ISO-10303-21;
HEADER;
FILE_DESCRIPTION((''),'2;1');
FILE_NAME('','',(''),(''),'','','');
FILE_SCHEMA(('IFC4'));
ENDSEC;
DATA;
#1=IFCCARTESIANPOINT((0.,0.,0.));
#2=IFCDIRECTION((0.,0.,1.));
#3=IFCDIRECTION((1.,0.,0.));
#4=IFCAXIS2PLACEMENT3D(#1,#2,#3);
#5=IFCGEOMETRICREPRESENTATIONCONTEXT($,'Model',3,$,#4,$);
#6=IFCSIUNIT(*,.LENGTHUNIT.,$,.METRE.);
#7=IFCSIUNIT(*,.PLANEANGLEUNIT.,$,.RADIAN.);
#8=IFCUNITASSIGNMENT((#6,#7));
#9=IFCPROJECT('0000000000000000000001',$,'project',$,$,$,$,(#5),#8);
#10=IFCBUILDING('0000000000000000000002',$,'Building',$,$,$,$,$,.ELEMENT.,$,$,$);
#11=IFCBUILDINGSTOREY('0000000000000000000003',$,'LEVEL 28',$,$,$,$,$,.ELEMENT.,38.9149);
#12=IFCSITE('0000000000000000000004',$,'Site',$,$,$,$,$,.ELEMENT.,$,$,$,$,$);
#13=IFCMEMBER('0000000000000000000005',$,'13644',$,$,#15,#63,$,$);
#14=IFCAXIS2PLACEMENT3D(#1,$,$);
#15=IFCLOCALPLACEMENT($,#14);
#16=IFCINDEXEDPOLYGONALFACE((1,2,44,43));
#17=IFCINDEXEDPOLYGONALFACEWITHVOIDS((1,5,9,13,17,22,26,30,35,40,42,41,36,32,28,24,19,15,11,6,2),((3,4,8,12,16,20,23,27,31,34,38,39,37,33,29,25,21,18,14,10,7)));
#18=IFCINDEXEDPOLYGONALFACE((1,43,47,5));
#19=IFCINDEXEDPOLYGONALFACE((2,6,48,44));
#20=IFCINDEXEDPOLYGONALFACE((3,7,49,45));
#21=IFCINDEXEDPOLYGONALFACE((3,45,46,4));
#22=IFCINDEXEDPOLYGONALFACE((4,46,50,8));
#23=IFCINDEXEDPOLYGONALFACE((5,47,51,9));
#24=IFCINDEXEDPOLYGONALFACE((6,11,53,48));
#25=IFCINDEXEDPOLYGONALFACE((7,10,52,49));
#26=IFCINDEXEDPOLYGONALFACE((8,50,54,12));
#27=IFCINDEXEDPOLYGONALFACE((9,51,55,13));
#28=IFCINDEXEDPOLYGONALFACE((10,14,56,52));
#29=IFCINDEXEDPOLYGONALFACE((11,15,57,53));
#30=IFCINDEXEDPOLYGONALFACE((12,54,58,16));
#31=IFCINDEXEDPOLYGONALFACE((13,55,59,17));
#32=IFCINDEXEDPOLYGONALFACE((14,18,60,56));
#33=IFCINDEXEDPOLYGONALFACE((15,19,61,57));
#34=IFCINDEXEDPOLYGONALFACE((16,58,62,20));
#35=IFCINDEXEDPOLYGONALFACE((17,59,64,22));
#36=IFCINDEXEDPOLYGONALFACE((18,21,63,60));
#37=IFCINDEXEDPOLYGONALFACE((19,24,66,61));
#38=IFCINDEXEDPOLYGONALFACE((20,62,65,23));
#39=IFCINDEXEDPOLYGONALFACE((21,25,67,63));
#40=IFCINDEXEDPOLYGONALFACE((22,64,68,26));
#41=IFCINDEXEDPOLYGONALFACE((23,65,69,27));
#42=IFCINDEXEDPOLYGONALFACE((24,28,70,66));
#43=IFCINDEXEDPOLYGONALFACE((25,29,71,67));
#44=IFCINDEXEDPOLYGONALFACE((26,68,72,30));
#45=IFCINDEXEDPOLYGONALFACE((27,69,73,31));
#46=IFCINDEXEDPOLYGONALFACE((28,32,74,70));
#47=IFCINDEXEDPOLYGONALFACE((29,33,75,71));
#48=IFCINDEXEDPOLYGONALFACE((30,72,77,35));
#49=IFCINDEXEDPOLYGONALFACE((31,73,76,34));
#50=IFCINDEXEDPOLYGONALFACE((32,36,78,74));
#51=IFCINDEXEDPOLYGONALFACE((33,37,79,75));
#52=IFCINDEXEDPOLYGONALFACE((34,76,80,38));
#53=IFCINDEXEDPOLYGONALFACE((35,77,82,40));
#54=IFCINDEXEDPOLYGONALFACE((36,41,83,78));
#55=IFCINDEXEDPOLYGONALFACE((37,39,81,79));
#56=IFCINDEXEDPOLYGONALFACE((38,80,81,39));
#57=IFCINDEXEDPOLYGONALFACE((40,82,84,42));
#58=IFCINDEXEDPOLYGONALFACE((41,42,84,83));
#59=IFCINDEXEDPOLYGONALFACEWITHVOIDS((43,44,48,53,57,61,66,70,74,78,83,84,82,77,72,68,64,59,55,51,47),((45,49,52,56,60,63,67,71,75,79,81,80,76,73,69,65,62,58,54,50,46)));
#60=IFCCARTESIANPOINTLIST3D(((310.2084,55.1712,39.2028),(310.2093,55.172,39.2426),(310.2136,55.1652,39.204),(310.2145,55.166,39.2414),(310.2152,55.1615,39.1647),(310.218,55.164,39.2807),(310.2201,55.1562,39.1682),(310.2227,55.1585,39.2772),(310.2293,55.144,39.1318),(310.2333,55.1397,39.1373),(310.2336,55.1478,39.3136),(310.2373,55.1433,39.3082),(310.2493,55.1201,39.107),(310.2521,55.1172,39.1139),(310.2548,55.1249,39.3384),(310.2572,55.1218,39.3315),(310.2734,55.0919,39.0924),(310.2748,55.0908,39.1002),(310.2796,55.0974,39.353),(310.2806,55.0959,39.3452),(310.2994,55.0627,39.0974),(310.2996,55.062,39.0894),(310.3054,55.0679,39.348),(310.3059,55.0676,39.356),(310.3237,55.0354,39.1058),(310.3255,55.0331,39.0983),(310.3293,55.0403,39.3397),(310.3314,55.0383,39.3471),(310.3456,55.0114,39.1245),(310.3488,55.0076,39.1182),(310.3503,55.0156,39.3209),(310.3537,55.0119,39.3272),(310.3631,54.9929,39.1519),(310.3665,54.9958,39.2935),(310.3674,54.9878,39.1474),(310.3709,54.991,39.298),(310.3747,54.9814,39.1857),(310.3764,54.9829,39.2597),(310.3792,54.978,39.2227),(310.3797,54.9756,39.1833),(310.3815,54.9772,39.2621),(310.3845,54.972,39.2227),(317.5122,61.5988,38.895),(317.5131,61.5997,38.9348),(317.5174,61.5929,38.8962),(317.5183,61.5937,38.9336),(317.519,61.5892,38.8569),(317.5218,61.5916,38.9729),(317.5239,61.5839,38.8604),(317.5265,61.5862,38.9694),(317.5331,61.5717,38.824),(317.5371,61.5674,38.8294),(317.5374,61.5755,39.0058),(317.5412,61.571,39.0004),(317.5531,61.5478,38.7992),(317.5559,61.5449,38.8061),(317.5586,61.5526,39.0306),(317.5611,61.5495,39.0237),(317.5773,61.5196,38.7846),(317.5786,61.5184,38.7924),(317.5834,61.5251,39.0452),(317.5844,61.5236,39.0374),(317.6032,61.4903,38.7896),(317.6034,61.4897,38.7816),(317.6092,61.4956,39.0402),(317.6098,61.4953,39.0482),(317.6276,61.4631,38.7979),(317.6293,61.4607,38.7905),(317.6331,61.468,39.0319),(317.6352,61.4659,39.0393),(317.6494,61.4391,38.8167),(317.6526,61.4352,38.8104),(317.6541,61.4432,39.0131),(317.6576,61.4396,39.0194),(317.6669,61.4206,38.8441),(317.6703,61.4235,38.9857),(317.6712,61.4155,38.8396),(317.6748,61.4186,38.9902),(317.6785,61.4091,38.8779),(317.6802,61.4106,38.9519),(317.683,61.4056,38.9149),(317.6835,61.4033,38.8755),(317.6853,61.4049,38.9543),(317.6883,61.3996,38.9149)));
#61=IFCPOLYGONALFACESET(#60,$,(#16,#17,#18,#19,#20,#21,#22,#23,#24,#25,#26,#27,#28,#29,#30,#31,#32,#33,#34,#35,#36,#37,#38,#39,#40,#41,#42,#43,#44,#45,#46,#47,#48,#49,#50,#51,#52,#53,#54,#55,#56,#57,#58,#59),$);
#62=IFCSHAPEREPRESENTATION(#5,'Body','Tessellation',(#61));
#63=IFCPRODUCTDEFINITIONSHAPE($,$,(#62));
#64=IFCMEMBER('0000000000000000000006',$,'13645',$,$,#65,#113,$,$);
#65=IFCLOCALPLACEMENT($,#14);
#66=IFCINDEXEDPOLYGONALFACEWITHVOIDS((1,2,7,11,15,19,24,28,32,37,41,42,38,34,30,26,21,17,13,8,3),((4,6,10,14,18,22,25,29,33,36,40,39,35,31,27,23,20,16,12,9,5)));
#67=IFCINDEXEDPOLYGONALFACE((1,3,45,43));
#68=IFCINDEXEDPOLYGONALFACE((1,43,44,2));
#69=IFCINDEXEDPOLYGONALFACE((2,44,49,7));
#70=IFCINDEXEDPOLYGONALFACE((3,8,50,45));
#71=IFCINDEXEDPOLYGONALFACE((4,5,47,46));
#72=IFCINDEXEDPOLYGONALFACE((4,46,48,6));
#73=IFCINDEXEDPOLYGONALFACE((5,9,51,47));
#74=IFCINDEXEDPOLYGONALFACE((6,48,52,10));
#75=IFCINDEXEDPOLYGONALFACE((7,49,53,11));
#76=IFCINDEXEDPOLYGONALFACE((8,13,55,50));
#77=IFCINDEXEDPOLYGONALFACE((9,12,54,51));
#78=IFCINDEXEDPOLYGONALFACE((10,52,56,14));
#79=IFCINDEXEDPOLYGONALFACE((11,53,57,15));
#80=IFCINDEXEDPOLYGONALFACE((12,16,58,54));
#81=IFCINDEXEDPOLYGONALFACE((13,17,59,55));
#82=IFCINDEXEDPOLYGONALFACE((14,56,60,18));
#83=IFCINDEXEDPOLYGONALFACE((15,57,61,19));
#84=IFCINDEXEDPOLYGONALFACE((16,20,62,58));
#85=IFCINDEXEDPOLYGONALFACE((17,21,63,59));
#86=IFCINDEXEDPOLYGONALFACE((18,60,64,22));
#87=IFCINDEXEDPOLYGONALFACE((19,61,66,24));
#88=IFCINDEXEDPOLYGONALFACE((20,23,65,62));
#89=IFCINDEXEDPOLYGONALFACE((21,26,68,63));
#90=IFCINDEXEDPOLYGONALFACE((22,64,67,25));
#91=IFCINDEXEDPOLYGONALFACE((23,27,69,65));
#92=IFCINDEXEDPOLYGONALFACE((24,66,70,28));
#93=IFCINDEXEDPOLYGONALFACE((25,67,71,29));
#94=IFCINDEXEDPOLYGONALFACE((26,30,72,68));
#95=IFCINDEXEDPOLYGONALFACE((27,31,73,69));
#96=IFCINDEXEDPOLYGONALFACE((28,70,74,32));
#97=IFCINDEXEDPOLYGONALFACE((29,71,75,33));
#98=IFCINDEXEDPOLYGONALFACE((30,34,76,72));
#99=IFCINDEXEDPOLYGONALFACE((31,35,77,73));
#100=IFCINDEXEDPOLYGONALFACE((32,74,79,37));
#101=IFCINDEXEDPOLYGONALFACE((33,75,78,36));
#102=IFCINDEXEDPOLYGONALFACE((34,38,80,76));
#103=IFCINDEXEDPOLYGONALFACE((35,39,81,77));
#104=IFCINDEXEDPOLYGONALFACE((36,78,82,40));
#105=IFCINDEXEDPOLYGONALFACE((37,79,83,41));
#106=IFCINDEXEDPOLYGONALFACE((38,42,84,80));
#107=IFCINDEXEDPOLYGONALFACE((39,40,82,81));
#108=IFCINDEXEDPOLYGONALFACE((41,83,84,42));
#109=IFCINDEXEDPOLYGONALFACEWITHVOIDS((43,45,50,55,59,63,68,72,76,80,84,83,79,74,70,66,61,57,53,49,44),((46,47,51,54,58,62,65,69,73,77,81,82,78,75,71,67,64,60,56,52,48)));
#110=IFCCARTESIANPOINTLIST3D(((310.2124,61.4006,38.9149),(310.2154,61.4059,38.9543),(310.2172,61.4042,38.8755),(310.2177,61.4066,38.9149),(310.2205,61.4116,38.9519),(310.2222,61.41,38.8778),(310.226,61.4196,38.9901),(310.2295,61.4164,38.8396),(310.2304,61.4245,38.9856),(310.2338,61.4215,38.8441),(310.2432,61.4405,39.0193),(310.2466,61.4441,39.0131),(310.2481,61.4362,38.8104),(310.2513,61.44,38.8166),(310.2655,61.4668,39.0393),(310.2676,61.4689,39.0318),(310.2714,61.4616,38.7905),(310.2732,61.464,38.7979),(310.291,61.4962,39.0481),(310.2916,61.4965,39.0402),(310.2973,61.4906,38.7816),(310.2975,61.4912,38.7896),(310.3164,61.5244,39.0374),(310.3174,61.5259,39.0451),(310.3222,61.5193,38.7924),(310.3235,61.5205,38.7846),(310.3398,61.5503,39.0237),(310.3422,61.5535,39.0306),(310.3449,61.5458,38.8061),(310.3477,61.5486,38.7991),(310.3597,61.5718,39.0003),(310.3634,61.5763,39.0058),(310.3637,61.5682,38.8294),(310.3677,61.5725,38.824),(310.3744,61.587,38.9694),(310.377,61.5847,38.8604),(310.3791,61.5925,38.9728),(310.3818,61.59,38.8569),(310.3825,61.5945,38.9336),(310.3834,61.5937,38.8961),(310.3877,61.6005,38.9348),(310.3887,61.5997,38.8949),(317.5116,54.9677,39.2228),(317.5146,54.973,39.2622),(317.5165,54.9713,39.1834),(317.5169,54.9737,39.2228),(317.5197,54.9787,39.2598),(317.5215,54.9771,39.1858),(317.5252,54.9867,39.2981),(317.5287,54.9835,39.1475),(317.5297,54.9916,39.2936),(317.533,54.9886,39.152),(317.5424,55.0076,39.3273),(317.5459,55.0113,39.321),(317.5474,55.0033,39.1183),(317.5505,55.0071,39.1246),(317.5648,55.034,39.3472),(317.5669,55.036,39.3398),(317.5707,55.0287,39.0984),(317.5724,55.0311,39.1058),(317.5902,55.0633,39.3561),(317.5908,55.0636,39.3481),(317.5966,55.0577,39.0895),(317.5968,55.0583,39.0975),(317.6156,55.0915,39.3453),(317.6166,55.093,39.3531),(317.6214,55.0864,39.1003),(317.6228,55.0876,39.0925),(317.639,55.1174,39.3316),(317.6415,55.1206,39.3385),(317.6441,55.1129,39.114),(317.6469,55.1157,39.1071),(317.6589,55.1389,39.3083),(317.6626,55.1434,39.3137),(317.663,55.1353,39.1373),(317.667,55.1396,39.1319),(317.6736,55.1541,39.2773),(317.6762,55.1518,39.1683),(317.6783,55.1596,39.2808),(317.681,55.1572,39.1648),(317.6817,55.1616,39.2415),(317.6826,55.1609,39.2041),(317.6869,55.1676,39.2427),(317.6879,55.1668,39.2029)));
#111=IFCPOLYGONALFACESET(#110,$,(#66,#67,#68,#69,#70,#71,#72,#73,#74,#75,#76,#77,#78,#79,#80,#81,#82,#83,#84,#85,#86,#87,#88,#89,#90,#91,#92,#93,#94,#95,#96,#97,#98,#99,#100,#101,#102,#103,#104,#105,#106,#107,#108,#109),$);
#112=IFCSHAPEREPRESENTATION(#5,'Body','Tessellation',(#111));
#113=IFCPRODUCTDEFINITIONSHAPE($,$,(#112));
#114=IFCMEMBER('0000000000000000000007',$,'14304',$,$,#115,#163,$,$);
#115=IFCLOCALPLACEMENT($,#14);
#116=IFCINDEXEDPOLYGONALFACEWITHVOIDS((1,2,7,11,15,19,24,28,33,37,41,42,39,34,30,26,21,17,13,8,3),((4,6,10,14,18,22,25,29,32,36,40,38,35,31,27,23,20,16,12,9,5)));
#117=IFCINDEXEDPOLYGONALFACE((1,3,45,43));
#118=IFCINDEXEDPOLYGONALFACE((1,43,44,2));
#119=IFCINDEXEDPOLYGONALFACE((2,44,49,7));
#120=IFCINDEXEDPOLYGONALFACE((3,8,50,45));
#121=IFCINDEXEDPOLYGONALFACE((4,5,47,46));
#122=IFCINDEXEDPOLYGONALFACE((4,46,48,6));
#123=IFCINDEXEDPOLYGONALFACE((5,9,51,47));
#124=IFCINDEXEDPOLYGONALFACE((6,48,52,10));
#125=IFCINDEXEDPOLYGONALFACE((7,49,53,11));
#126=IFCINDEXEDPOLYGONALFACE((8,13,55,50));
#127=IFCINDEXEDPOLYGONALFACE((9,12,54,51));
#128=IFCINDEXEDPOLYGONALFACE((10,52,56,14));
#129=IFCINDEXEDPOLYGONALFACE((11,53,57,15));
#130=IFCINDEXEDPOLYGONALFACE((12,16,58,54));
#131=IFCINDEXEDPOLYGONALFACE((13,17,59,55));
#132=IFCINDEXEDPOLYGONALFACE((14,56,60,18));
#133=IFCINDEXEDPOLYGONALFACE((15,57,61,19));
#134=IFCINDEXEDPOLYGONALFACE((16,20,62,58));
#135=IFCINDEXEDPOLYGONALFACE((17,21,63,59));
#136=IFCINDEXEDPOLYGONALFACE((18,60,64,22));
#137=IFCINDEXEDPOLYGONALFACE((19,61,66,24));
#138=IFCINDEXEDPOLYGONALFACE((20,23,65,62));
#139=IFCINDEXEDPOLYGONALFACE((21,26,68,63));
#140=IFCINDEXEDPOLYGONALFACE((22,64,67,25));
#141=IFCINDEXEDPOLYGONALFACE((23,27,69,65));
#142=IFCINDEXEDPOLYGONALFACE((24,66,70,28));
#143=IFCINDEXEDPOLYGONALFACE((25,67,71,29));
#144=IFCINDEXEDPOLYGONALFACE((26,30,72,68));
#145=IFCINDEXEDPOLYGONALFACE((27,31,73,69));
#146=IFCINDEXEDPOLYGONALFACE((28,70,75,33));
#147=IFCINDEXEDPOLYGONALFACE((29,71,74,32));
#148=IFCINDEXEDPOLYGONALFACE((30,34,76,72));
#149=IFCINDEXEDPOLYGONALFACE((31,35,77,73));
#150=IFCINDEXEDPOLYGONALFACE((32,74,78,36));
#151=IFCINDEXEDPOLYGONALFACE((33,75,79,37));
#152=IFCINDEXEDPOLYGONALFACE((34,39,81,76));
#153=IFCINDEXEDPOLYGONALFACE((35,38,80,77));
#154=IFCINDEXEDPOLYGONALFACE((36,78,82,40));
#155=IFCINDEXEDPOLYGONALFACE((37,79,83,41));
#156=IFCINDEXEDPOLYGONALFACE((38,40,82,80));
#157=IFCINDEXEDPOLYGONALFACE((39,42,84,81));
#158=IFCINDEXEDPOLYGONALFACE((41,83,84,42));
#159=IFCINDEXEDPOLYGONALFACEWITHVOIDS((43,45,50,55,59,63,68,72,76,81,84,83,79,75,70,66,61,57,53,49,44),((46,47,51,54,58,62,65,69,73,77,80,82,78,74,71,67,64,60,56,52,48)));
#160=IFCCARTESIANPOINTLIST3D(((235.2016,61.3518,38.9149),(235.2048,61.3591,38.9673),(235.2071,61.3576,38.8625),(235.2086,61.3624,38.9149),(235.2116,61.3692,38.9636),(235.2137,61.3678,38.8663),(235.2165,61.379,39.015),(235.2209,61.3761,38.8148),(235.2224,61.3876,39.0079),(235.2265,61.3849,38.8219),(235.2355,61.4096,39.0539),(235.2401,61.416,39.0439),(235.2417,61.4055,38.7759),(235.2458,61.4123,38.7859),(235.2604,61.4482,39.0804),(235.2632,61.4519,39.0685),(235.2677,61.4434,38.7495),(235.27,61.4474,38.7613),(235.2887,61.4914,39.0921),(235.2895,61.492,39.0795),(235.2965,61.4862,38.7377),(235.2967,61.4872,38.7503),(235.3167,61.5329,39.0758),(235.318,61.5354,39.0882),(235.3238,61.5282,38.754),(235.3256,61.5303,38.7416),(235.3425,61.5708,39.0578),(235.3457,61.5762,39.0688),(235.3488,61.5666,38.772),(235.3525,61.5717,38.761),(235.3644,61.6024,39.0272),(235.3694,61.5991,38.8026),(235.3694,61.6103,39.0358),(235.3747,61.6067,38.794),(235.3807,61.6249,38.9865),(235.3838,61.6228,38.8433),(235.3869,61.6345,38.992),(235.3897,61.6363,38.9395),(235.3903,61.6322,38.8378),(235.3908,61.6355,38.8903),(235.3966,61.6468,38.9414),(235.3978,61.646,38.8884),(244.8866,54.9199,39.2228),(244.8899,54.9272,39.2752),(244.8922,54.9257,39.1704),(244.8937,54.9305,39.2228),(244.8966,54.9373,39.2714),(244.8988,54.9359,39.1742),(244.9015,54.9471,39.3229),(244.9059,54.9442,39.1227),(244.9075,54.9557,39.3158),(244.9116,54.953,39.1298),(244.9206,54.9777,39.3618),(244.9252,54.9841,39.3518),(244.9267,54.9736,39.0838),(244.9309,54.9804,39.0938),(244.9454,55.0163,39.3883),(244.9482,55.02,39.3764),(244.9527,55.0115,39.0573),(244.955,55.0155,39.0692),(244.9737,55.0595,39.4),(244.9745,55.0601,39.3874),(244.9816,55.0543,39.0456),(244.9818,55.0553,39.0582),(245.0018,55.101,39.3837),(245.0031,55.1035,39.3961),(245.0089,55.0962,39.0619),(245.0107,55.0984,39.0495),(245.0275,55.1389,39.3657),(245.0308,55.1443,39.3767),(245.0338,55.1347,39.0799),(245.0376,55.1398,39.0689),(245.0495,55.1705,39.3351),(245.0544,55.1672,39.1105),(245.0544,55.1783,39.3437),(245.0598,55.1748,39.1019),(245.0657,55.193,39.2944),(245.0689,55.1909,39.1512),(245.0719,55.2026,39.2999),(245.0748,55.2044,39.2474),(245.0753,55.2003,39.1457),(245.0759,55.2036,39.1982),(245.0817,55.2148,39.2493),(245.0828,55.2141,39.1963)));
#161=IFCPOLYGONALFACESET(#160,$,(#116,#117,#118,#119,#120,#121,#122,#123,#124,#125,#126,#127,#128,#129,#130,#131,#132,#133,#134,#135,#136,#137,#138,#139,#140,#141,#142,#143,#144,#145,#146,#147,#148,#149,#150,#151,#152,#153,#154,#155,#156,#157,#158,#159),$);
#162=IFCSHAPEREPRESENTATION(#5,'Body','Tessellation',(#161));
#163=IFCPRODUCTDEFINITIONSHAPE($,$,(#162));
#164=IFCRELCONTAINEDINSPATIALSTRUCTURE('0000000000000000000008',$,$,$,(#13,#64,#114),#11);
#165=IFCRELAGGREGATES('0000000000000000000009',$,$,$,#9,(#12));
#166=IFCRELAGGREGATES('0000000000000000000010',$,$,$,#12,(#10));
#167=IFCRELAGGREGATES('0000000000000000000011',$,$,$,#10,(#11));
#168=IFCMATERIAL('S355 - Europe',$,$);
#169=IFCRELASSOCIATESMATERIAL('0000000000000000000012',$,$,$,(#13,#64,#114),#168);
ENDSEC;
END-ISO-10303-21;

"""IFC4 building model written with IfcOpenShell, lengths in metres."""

from ifc_helpers import new_model, si_unit, frame, origin_with_axes, origin_2d_with_axis, place, context, project, spatial, hollow_circle, extrude, material, material_profile, profile_set, profile_usage, element, save


model = new_model("IFC4")

# Units and contexts
model_context = context("Model", 3, world=origin_with_axes())
ifc_project = project(units=[si_unit("LENGTHUNIT", "METRE"), si_unit("PLANEANGLEUNIT", "RADIAN")], contexts=[model_context])

# Site, building, storey
site = spatial("IfcSite", under=ifc_project, Name="Site", CompositionType="ELEMENT")
building = spatial("IfcBuilding", under=site, Name="Building", CompositionType="ELEMENT")
storey = spatial("IfcBuildingStorey", under=building, Name="LEVEL 28", CompositionType="ELEMENT", Elevation=38.9149)

# Shared definitions
ifc_material = material(Name="S355 - Europe")

# Members
ifc_material_profile_1 = material_profile(ifc_material, hollow_circle(Radius=0.1337, WallThickness=0.008, at=origin_2d_with_axis()))
ifc_profile_set_1 = profile_set([ifc_material_profile_1])
ifc_profile_usage_1 = profile_usage(ifc_profile_set_1, cardinal=10)
member_1_placement = place(None, frame((317.6, 61.5, 38.9149), z_axis=(-0.750322, -0.660315, 0.031621), x_axis=(0.660646, -0.750698, 0.0)))
element("IfcMember", 1, at=member_1_placement, inside=storey, material=ifc_profile_usage_1, Name="13644", context=model_context, shape_type="SweptSolid", body=[
    extrude(hollow_circle(Radius=0.1337, WallThickness=0.008, at=origin_2d_with_axis()), origin_with_axes(), (0.0, 0.0, 1.0), 9.7342),
])
ifc_material_profile_2 = material_profile(ifc_material, hollow_circle(Radius=0.1337, WallThickness=0.008, at=origin_2d_with_axis()))
ifc_profile_set_2 = profile_set([ifc_material_profile_2])
ifc_profile_usage_2 = profile_usage(ifc_profile_set_2, cardinal=10)
member_2_placement = place(None, frame((317.6, 55.068, 39.2228), z_axis=(-0.749849, 0.660852, -0.031634), x_axis=(-0.661698, -0.74977, 0.0)))
element("IfcMember", 2, at=member_2_placement, inside=storey, material=ifc_profile_usage_2, Name="13645", context=model_context, shape_type="SweptSolid", body=[
    extrude(hollow_circle(Radius=0.1337, WallThickness=0.008, at=origin_2d_with_axis()), origin_with_axes(), (0.0, 0.0, 1.0), 9.7342),
])
ifc_material_profile_3 = material_profile(ifc_material, hollow_circle(Radius=0.1778, WallThickness=0.0127, at=origin_2d_with_axis()))
ifc_profile_set_3 = profile_set([ifc_material_profile_3])
ifc_profile_usage_3 = profile_usage(ifc_profile_set_3, cardinal=10)
member_3_placement = place(None, frame((244.985, 55.068, 39.2228), z_axis=(-0.832742, 0.553029, -0.026473), x_axis=(-0.553231, -0.833028, 0.0)))
element("IfcMember", 3, at=member_3_placement, inside=storey, material=ifc_profile_usage_3, Name="14304", context=model_context, shape_type="SweptSolid", body=[
    extrude(hollow_circle(Radius=0.1778, WallThickness=0.0127, at=origin_2d_with_axis()), origin_with_axes(), (0.0, 0.0, 1.0), 11.6303),
])

save(model, "model.ifc")
